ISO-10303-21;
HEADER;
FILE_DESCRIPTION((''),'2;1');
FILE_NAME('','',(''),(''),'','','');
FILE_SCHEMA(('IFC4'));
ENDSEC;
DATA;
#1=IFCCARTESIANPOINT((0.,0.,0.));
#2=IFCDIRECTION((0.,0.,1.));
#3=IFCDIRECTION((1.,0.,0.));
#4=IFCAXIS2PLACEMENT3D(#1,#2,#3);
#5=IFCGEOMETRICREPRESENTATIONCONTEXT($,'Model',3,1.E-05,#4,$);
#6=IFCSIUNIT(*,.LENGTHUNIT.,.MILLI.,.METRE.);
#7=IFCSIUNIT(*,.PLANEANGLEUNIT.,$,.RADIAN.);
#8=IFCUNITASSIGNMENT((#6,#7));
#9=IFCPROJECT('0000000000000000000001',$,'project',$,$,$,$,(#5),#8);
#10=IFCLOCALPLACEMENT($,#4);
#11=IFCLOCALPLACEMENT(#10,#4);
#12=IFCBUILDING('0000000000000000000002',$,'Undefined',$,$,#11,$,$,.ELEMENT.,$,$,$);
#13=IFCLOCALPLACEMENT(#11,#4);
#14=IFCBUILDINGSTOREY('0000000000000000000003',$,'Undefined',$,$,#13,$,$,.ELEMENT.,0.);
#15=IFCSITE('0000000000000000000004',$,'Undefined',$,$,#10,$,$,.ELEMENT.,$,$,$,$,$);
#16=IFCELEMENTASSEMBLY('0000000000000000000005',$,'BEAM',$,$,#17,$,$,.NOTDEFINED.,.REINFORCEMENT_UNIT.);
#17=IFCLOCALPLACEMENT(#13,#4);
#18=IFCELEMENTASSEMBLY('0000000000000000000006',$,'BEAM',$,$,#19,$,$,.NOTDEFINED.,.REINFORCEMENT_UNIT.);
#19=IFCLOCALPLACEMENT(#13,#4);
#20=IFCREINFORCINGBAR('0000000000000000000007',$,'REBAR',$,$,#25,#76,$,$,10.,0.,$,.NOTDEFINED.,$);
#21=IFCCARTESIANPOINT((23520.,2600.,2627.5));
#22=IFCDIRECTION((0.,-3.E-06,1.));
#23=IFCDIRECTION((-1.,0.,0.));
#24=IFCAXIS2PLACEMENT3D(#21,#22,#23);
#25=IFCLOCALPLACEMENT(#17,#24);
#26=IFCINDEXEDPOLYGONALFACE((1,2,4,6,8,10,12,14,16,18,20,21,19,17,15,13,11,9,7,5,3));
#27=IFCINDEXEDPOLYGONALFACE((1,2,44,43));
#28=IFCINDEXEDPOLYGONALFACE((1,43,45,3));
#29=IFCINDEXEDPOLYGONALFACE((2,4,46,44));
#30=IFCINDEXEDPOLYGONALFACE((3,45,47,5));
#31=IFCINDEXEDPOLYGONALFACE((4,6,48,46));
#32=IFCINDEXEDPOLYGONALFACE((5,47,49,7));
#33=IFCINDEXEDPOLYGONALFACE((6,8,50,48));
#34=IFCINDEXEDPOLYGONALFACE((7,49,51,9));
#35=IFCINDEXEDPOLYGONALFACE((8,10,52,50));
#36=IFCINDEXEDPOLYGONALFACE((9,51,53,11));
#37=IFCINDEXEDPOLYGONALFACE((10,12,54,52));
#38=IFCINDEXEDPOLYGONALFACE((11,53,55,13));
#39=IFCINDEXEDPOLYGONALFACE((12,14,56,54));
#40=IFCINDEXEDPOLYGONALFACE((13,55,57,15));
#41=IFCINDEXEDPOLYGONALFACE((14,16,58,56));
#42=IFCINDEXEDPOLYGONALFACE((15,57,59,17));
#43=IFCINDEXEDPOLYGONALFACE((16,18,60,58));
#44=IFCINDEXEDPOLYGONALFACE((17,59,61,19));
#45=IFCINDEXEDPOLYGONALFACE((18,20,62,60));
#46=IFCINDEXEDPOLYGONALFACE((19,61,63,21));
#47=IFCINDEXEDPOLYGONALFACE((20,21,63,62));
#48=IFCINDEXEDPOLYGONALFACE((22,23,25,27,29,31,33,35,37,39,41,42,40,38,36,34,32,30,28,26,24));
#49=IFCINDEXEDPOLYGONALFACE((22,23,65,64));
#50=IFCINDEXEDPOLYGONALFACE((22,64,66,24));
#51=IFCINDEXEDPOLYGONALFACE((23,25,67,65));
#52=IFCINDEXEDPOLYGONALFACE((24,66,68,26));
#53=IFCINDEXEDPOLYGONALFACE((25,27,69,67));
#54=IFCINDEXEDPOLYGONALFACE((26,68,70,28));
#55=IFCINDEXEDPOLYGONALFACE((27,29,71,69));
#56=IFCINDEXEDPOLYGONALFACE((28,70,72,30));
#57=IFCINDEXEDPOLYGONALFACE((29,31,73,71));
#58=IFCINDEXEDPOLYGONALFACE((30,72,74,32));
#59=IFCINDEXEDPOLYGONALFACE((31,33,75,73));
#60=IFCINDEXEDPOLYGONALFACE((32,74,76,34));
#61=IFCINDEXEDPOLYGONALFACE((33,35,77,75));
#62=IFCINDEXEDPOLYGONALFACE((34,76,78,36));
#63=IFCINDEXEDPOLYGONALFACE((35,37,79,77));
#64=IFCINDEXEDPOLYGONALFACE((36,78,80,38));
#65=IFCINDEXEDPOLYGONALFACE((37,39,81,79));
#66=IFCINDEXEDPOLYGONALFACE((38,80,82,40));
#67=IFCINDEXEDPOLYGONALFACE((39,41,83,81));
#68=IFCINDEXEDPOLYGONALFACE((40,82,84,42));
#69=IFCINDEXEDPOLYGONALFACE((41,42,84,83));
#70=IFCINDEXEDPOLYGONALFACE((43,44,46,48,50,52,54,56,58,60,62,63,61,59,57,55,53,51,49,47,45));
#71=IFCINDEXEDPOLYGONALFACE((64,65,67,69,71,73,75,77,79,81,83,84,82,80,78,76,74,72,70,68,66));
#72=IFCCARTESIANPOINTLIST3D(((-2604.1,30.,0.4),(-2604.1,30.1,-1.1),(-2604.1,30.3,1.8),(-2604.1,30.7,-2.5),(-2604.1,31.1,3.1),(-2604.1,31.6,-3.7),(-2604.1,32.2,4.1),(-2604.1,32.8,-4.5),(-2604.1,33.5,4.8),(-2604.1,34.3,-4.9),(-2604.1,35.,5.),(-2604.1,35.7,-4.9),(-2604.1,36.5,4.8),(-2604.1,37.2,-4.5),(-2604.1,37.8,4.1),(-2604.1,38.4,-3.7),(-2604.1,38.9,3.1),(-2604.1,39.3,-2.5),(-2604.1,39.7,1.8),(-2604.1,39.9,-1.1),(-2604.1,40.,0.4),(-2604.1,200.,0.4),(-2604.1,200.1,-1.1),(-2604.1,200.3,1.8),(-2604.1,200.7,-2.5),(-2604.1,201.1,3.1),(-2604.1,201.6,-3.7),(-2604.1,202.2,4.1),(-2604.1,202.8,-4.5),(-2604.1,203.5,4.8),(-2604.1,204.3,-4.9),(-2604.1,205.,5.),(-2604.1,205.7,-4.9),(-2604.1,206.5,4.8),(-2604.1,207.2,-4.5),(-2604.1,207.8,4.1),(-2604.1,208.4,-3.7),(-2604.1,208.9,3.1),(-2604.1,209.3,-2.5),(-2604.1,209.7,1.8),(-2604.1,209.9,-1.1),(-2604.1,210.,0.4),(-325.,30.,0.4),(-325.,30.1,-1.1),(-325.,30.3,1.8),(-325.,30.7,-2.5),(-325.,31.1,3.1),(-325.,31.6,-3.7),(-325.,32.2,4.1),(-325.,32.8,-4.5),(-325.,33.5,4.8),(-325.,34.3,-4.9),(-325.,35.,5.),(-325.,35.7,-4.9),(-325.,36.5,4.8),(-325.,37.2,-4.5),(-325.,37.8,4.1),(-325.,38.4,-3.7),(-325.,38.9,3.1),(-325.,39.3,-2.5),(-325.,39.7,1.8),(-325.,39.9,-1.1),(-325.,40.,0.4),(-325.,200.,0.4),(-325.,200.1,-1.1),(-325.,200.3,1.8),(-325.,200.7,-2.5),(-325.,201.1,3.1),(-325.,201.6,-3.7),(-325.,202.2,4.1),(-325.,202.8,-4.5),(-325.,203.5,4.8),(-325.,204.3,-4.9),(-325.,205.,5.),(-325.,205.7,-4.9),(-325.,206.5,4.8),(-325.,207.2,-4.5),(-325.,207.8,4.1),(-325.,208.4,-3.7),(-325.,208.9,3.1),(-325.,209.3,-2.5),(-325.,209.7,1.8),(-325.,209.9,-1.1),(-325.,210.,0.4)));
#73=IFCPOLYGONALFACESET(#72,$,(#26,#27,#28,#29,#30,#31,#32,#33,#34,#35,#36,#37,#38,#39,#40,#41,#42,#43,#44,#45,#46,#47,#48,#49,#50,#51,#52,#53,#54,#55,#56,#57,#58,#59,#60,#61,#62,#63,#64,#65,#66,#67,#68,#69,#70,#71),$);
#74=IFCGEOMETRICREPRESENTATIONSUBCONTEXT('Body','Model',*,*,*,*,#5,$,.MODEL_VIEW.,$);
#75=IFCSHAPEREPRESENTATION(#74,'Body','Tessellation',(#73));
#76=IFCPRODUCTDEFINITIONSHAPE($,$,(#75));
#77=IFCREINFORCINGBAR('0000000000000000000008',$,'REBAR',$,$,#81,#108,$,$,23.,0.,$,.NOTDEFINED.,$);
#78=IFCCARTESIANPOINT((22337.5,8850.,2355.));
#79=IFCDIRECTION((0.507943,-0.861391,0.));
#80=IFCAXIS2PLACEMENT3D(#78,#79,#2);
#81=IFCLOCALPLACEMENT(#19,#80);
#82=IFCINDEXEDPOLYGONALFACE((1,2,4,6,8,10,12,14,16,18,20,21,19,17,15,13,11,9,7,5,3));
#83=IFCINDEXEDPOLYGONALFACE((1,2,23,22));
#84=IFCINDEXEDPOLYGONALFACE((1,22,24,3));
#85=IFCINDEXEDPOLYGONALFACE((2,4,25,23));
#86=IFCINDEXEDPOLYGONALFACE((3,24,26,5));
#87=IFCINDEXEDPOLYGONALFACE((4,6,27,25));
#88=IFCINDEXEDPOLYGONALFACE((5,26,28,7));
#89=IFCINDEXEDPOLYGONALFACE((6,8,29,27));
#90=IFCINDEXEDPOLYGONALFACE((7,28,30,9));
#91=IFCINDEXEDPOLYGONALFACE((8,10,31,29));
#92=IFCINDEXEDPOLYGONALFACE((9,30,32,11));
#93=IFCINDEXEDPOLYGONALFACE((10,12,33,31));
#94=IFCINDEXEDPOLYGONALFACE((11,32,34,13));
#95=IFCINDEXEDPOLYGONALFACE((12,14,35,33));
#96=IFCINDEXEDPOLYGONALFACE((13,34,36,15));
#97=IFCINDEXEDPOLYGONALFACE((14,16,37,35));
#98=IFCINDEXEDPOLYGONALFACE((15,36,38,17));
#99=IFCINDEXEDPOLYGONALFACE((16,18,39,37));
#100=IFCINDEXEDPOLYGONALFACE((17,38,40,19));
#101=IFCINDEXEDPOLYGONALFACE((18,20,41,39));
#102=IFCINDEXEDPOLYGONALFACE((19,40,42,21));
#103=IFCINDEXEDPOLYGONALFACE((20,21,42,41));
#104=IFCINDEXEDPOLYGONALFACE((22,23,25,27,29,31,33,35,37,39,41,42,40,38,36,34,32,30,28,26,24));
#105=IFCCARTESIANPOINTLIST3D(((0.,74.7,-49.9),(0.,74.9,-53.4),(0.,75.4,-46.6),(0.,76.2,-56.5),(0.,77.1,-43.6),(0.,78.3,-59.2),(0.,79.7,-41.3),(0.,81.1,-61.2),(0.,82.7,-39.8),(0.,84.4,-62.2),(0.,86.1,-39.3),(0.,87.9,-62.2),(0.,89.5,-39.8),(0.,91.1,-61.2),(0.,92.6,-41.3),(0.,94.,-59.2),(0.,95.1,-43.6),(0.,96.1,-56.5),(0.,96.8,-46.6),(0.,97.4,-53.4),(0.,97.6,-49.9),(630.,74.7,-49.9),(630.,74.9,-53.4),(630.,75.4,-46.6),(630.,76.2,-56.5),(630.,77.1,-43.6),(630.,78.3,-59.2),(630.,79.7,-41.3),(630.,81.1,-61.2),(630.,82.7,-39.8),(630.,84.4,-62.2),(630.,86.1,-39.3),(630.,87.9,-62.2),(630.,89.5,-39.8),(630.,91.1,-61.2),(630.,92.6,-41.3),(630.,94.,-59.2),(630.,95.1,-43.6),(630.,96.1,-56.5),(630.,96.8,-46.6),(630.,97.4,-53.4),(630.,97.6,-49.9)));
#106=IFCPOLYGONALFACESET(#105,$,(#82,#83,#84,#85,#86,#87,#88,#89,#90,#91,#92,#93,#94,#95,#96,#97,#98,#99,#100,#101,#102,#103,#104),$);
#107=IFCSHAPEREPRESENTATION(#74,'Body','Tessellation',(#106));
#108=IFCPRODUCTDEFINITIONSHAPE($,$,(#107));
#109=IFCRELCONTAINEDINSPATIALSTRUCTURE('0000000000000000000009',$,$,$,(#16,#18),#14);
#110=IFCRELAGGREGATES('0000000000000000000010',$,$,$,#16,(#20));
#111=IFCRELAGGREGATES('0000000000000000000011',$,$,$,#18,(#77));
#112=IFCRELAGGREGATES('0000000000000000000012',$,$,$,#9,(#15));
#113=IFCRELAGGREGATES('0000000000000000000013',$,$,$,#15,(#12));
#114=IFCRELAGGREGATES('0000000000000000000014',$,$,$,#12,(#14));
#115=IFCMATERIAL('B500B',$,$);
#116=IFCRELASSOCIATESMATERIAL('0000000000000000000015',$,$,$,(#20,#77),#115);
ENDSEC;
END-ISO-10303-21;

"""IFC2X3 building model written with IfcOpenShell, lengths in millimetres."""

from ifc_helpers import new_model, entity, si_unit, frame, origin_with_axes, place, context, subcontext, project, spatial, source, transform, mapped, material, element, aggregate, save


model = new_model("IFC2X3")

# Units and contexts
model_context = context("Model", 3, precision=1e-05, world=origin_with_axes())
body_context = subcontext(model_context, "Body", "Model", "MODEL_VIEW")
ifc_project = project(units=[si_unit("LENGTHUNIT", "METRE", prefix="MILLI"), si_unit("PLANEANGLEUNIT", "RADIAN")], contexts=[model_context])

# Site, building, storey
site_placement = place(None, origin_with_axes())
site = spatial("IfcSite", under=ifc_project, at=site_placement, Name="Undefined", CompositionType="ELEMENT")
building_placement = place(site_placement, origin_with_axes())
building = spatial("IfcBuilding", under=site, at=building_placement, Name="Undefined", CompositionType="ELEMENT")
storey_placement = place(building_placement, origin_with_axes())
storey = spatial("IfcBuildingStorey", under=building, at=storey_placement, Name="Undefined", CompositionType="ELEMENT", Elevation=0.0)

# Element assembly
assembly_1_placement = place(storey_placement, origin_with_axes())
assembly_1 = element("IfcElementAssembly", 1, at=assembly_1_placement, inside=storey, Name="BEAM", AssemblyPlace="NOTDEFINED", PredefinedType="REINFORCEMENT_UNIT")

# Element assembly
assembly_2_placement = place(storey_placement, origin_with_axes())
assembly_2 = element("IfcElementAssembly", 2, at=assembly_2_placement, inside=storey, Name="BEAM", AssemblyPlace="NOTDEFINED", PredefinedType="REINFORCEMENT_UNIT")

# Reinforcing bars
ifc_material_1 = material(Name="B500B")
shared_shape_1 = source(origin_with_axes(), body_context, "Body", "AdvancedSweptSolid", [
    entity("IfcSweptDiskSolid", entity("IfcTrimmedCurve", entity("IfcLine", entity("IfcCartesianPoint", [0.0, 0.0, 0.0]), entity("IfcVector", entity("IfcDirection", [1.0, 0.0, 0.0]), 1.0)), [entity("IfcParameterValue", 0.0)], [entity("IfcParameterValue", 2279.092833)], True, "PARAMETER"), 5.0, None, 0.0, 2279.1),
])
shared_shape_2 = source(origin_with_axes(), body_context, "Body", "AdvancedSweptSolid", [
    entity("IfcSweptDiskSolid", entity("IfcTrimmedCurve", entity("IfcLine", entity("IfcCartesianPoint", [0.0, 0.0, 0.0]), entity("IfcVector", entity("IfcDirection", [1.0, 0.0, 0.0]), 1.0)), [entity("IfcParameterValue", 0.0)], [entity("IfcParameterValue", 2279.092833)], True, "PARAMETER"), 5.0, None, 0.0, 2279.1),
])
reinforcing_bar_1_placement = place(assembly_1_placement, frame((23520.0, 2600.0, 2627.5), z_axis=(0.0, -0.000003, 1.0), x_axis=(-1.0, 0.0, 0.0)))
reinforcing_bar_1 = element("IfcReinforcingBar", 3, at=reinforcing_bar_1_placement, material=ifc_material_1, Name="REBAR", BarRole="NOTDEFINED", CrossSectionArea=0.0, NominalDiameter=10.0, context=body_context, shape_type="MappedRepresentation", body=[
    mapped(shared_shape_1, transform((-2604.1, 35.0, 0.0))),
    mapped(shared_shape_2, transform((-2604.1, 205.0, 0.0))),
])
aggregate(assembly_1, [reinforcing_bar_1])
shared_shape_3 = source(origin_with_axes(), body_context, "Body", "AdvancedSweptSolid", [
    entity("IfcSweptDiskSolid", entity("IfcTrimmedCurve", entity("IfcLine", entity("IfcCartesianPoint", [0.0, 0.0, 0.0]), entity("IfcVector", entity("IfcDirection", [1.0, 0.0, 0.0]), 1.0)), [entity("IfcParameterValue", 0.0)], [entity("IfcParameterValue", 630.0)], True, "PARAMETER"), 11.5, None, 0.0, 630.0),
])
reinforcing_bar_2_placement = place(assembly_2_placement, frame((22337.5, 8850.0, 2355.0), z_axis=(0.507943, -0.861391, 0.0), x_axis=(0.0, 0.0, 1.0)))
reinforcing_bar_2 = element("IfcReinforcingBar", 4, at=reinforcing_bar_2_placement, material=ifc_material_1, Name="REBAR", BarRole="NOTDEFINED", CrossSectionArea=0.0, NominalDiameter=23.0, context=body_context, shape_type="MappedRepresentation", body=[
    mapped(shared_shape_3, transform((0.0, 86.1, -50.8))),
])
aggregate(assembly_2, [reinforcing_bar_2])

save(model, "model.ifc")
